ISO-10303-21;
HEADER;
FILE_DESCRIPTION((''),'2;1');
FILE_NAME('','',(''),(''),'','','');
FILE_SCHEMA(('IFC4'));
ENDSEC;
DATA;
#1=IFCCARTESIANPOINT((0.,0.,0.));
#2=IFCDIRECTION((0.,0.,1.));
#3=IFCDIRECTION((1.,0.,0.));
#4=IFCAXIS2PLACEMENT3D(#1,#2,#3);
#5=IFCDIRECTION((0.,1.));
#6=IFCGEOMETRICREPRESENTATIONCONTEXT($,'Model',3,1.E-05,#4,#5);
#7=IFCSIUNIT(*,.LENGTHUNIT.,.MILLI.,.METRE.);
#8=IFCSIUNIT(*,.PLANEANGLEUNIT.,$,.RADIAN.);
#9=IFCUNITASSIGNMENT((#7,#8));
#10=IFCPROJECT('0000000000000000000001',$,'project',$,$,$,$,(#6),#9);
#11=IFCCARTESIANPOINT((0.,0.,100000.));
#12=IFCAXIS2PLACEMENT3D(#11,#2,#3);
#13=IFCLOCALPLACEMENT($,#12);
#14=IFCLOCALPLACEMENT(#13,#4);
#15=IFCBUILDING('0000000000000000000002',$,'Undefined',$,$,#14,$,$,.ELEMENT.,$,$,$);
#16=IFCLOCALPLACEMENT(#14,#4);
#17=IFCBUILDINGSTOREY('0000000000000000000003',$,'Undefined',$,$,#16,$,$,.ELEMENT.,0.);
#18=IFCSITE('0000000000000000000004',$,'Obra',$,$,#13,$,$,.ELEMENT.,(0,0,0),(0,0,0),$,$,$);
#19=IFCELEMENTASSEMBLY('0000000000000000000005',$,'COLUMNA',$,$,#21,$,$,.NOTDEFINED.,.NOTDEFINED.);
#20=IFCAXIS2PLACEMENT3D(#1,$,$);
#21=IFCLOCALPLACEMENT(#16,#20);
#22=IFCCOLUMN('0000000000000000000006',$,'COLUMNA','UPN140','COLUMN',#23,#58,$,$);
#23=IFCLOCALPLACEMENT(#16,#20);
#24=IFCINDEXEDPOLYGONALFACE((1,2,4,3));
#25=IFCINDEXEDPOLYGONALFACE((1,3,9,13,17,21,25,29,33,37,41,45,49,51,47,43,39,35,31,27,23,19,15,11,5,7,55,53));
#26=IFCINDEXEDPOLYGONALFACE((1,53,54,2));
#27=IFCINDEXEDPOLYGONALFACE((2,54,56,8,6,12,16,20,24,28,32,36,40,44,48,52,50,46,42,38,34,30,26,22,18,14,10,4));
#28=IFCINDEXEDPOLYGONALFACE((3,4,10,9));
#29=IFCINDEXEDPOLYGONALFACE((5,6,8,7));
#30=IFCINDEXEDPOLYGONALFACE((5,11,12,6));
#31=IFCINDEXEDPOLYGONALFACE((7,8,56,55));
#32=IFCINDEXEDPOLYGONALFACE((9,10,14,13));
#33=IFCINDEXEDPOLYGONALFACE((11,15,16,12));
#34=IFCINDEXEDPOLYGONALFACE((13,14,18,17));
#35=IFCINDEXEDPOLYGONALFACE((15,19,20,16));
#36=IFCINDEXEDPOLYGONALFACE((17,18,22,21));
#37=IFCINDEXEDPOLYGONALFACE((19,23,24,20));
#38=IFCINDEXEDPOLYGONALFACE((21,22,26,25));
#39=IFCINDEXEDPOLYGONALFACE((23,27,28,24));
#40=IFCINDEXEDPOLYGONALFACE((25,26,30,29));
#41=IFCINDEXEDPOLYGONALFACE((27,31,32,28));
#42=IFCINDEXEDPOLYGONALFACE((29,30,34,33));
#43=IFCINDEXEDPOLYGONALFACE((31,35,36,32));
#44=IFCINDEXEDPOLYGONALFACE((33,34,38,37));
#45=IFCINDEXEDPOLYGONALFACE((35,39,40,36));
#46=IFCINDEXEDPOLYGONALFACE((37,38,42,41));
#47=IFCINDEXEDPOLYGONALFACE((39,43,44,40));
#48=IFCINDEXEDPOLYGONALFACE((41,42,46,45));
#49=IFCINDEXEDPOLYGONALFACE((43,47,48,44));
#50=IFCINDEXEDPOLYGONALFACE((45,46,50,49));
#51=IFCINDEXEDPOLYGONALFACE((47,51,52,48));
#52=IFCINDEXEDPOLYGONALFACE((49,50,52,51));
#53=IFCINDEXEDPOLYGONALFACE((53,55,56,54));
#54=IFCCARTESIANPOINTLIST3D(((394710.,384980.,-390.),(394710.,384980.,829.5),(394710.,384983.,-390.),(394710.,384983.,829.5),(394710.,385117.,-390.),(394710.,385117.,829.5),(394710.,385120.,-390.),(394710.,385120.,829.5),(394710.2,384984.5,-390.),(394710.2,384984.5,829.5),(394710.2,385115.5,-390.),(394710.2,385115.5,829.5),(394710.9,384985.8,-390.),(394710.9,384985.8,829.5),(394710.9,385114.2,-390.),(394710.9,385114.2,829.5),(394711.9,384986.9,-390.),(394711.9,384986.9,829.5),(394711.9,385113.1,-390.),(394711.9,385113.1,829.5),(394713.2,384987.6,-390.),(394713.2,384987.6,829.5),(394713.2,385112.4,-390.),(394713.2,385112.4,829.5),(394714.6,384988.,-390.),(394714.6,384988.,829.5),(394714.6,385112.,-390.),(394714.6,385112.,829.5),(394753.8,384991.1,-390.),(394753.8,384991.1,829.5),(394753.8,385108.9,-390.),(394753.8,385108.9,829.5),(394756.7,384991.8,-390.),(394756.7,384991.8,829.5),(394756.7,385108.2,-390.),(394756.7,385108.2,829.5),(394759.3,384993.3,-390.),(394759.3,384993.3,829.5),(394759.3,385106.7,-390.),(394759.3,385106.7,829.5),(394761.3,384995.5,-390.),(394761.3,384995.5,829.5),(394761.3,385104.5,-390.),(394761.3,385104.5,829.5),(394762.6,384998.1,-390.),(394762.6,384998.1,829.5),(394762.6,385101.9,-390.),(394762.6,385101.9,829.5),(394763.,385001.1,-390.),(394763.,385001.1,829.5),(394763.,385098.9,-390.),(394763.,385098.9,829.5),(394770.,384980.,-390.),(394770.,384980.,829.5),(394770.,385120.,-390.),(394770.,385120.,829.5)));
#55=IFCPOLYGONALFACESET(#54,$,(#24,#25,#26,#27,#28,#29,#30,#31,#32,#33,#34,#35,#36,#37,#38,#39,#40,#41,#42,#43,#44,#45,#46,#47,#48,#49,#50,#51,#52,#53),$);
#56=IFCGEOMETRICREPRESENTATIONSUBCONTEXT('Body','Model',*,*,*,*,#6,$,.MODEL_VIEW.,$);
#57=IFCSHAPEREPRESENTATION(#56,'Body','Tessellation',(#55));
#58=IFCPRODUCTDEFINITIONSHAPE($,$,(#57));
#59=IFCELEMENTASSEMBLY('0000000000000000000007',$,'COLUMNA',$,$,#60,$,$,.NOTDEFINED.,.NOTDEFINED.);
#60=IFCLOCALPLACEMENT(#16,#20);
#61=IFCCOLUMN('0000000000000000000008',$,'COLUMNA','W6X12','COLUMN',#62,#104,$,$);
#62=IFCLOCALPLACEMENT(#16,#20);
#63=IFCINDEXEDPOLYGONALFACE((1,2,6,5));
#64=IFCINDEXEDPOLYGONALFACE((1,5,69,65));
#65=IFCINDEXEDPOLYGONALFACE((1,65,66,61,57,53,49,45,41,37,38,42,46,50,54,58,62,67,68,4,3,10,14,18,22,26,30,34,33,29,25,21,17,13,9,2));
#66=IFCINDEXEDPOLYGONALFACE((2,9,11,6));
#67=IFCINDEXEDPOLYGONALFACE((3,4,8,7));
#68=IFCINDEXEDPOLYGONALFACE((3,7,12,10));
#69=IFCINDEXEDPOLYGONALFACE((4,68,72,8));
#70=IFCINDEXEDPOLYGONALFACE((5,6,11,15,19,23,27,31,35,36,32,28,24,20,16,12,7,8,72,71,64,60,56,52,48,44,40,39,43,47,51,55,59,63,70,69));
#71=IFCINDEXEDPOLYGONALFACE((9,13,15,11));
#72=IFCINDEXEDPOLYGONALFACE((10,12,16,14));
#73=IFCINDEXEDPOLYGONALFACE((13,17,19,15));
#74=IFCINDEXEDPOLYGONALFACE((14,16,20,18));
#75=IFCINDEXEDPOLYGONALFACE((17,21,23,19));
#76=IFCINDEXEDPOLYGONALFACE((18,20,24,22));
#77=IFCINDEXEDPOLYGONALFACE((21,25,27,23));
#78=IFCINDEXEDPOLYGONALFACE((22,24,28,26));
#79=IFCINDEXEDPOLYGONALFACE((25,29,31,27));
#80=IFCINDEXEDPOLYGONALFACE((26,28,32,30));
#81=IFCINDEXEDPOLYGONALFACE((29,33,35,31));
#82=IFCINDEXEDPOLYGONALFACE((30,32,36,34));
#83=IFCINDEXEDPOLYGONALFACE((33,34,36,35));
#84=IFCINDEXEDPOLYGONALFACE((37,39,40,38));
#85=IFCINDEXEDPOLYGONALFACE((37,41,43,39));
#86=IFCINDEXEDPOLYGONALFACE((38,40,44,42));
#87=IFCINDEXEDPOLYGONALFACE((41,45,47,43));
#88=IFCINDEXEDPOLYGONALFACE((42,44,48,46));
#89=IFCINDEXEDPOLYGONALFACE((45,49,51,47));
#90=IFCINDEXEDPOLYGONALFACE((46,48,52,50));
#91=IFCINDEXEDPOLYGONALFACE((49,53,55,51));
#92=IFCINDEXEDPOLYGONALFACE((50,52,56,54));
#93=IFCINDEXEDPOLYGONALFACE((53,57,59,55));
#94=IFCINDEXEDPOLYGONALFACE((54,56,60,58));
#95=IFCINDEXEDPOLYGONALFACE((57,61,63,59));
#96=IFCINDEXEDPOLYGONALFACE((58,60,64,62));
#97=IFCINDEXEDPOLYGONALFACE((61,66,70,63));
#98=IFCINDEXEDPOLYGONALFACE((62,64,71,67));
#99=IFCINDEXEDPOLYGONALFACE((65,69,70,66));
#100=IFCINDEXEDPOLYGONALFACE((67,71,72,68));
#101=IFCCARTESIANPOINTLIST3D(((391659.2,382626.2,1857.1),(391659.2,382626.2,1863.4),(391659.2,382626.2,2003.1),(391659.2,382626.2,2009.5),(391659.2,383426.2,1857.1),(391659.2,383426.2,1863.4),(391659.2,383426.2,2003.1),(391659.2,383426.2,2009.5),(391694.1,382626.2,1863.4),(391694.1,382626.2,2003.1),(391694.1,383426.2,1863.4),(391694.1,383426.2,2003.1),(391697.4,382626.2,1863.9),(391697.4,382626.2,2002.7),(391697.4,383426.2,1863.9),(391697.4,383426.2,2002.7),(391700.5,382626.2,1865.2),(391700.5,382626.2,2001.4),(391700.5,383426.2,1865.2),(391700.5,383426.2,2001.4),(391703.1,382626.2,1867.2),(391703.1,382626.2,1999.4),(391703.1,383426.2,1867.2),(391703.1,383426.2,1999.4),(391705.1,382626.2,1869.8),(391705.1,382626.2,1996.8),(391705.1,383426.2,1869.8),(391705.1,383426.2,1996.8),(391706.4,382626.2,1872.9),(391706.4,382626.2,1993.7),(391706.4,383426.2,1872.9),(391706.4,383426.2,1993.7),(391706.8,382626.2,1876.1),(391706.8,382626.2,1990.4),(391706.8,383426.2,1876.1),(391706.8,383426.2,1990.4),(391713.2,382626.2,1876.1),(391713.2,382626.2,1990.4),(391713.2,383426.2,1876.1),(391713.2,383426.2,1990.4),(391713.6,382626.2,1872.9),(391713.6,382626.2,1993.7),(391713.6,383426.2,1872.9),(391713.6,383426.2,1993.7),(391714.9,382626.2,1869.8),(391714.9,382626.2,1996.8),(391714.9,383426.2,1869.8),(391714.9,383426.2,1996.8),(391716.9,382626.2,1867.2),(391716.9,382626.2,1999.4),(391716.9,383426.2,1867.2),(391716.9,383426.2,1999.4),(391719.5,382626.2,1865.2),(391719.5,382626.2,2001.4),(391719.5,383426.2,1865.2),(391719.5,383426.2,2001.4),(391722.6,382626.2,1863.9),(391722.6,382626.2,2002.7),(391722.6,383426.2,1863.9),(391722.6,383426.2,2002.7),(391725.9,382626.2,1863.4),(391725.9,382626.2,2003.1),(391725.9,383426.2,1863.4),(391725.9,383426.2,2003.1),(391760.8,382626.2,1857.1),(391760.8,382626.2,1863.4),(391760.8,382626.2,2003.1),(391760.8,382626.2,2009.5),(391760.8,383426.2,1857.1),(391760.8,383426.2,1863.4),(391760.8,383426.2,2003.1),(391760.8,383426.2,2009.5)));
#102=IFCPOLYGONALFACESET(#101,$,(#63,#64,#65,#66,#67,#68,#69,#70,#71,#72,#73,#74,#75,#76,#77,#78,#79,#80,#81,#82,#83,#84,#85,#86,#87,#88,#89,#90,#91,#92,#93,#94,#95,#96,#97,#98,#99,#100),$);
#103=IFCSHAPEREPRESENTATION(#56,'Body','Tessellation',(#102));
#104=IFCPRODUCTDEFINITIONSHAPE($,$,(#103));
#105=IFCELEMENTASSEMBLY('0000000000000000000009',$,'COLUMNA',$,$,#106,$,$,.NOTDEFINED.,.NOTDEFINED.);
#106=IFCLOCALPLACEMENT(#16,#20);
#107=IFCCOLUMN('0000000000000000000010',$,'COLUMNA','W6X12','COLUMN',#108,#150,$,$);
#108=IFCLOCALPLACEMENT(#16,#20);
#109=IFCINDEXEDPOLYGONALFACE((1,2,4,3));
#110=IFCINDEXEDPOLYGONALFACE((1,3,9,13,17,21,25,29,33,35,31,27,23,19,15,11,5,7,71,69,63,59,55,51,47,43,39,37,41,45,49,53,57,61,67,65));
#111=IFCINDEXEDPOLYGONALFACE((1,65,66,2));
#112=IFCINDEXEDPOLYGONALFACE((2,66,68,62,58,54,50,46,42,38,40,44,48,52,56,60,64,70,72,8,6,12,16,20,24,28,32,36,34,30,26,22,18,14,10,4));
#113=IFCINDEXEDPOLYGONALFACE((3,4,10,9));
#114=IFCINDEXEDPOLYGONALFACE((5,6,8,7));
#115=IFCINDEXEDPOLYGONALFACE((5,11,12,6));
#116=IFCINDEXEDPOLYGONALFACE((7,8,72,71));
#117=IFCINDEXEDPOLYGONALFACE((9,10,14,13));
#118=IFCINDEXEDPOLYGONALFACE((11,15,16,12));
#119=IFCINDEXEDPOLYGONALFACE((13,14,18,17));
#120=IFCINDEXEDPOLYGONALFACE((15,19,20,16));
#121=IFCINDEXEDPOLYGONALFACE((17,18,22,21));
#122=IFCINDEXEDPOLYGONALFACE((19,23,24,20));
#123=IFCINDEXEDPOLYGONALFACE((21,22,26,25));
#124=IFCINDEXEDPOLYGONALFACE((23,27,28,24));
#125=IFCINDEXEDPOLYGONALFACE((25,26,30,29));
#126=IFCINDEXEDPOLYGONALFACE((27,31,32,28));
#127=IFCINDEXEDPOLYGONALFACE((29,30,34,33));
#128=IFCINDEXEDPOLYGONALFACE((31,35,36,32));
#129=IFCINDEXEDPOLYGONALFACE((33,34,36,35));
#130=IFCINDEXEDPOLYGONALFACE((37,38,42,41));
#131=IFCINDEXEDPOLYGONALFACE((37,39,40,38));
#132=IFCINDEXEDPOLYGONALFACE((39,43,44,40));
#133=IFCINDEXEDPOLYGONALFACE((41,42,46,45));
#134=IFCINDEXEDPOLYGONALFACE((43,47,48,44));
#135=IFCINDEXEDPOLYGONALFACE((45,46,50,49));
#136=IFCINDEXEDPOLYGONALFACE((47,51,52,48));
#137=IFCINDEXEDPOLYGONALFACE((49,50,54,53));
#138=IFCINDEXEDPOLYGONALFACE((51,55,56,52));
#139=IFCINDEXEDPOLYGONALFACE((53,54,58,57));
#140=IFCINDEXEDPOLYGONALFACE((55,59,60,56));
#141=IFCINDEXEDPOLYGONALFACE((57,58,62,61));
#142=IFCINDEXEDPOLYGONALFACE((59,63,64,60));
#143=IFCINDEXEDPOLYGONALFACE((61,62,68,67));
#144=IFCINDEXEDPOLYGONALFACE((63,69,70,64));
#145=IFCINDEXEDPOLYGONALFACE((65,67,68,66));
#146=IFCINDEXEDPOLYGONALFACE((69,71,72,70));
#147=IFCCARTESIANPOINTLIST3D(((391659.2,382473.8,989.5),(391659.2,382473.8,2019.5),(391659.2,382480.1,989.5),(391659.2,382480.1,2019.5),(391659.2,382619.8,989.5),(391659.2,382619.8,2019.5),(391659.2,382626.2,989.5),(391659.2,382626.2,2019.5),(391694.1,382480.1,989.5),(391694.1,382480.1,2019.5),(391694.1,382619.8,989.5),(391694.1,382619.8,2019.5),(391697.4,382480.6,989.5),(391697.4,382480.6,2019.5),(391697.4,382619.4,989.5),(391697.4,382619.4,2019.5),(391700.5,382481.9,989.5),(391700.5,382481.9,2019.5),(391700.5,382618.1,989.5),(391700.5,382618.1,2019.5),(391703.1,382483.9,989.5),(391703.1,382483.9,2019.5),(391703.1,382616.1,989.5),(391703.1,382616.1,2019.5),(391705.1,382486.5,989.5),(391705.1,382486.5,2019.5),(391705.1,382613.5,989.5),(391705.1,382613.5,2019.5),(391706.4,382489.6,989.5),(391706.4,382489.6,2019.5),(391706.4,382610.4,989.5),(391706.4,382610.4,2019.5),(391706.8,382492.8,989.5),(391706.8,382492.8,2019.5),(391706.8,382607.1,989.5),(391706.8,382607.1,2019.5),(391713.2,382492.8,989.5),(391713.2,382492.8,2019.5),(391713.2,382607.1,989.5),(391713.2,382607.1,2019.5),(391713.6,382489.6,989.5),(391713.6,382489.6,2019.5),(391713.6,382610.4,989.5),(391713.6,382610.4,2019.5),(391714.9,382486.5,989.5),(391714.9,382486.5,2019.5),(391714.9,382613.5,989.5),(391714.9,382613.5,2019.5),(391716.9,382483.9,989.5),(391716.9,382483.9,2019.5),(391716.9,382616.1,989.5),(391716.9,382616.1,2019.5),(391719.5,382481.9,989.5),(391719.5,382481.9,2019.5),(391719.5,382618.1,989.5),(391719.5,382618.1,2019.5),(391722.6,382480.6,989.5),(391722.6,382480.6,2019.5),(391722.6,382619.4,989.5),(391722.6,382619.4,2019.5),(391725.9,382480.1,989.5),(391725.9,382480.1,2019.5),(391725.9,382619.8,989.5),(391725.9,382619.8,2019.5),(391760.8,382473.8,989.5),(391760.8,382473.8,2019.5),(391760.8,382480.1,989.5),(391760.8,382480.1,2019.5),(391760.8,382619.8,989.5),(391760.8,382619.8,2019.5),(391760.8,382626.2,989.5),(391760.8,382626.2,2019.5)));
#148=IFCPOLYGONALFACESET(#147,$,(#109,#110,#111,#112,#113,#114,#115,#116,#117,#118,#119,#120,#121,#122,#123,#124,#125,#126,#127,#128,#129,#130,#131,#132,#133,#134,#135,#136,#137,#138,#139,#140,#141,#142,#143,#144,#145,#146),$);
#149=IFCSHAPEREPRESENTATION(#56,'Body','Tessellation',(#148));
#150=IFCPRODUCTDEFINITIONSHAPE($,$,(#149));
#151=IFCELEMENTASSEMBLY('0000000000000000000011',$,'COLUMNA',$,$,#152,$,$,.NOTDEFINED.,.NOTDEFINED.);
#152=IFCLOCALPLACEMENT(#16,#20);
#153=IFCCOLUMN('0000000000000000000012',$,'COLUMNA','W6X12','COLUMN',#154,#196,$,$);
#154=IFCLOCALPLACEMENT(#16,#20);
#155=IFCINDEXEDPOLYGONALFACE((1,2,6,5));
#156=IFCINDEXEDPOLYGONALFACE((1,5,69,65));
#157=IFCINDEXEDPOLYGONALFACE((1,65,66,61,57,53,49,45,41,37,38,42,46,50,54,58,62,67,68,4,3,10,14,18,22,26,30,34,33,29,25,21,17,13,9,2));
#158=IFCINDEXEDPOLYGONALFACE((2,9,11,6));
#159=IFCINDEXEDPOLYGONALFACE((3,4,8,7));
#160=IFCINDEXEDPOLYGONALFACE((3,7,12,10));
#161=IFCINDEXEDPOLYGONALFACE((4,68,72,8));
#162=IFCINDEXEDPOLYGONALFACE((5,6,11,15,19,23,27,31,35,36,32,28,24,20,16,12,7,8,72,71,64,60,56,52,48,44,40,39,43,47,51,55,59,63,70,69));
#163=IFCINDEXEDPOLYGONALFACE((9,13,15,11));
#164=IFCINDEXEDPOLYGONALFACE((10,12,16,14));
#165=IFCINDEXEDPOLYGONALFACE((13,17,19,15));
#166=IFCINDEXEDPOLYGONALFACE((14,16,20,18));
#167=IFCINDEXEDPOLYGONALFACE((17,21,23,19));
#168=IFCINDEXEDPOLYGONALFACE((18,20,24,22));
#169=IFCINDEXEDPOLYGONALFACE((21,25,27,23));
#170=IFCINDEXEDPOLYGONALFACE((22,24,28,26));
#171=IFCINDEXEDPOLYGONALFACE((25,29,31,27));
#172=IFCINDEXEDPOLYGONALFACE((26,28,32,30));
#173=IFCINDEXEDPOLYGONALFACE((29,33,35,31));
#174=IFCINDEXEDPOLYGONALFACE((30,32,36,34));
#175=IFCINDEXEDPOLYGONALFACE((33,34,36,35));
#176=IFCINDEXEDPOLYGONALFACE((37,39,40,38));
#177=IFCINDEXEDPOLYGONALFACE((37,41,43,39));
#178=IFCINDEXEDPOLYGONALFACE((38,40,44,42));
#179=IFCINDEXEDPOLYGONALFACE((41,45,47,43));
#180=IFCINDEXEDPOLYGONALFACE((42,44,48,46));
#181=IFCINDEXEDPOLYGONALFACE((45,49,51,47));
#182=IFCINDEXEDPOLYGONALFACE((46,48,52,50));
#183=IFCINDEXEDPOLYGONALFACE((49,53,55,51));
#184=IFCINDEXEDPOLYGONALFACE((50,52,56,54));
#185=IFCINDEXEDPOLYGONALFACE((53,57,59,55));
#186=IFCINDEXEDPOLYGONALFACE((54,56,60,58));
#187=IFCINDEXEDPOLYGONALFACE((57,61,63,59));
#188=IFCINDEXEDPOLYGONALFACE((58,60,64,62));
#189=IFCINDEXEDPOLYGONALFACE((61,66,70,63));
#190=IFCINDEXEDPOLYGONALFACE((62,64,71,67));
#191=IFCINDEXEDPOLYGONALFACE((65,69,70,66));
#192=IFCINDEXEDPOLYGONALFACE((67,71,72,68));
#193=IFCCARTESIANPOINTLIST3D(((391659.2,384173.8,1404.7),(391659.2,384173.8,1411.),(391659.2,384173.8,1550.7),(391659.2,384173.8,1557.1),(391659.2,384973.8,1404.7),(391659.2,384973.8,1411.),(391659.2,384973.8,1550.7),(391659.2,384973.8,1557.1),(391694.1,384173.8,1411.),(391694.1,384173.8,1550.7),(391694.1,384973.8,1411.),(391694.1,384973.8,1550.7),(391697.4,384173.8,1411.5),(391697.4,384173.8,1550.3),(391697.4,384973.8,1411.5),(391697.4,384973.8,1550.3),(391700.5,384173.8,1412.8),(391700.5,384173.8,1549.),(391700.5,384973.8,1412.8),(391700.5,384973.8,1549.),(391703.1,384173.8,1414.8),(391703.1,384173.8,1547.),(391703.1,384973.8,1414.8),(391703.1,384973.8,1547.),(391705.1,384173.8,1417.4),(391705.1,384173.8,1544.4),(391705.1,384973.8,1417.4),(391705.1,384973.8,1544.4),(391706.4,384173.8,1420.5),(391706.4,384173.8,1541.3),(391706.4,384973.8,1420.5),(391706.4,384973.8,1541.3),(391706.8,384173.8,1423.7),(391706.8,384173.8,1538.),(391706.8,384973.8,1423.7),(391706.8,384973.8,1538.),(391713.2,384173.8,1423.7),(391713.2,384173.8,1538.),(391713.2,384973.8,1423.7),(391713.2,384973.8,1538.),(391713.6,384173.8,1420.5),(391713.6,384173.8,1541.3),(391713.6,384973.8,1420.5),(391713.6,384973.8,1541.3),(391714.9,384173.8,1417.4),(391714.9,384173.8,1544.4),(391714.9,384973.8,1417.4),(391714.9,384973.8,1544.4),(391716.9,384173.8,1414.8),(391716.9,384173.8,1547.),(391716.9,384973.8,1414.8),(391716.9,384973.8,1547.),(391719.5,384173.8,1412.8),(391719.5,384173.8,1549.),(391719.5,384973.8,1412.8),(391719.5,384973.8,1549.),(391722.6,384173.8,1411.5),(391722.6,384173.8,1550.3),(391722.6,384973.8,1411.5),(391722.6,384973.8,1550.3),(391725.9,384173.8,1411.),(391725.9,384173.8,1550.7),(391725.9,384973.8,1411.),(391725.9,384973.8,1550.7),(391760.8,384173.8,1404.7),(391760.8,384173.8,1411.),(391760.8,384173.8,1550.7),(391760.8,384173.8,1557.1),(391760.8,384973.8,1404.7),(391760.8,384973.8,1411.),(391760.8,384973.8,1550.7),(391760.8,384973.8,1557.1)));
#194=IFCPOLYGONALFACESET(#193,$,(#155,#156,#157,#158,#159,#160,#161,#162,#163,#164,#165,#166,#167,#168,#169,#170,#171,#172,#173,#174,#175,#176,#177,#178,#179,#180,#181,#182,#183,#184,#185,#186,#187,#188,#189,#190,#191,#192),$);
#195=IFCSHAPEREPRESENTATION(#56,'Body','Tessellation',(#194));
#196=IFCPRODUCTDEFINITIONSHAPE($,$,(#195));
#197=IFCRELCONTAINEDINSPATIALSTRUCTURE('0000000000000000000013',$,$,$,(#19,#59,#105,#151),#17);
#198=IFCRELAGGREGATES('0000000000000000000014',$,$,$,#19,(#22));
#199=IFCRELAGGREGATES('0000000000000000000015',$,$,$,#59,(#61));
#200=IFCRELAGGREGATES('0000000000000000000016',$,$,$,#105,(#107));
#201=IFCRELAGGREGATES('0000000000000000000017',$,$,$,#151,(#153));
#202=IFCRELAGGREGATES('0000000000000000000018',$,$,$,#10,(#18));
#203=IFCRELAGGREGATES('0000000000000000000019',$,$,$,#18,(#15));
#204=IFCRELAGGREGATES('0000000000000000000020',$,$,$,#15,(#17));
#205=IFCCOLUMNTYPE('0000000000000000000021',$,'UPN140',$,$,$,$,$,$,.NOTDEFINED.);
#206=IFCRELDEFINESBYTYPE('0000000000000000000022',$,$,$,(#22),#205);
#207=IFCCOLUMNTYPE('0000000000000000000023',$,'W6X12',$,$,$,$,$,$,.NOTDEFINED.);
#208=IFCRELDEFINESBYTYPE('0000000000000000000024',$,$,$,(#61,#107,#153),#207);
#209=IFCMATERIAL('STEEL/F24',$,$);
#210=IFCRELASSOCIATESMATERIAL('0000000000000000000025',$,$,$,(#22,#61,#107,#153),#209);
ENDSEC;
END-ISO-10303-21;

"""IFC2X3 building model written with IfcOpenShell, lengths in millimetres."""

from ifc_helpers import new_model, si_unit, direction, frame, origin_with_axes, origin_2d_with_axis, place, context, subcontext, project, spatial, i_section, u_section, extrude, material, type_object, element, aggregate, save


model = new_model("IFC2X3")

# Units and contexts
model_context = context("Model", 3, precision=1e-05, world=origin_with_axes(), true_north=direction((0.0, 1.0)))
body_context = subcontext(model_context, "Body", "Model", "MODEL_VIEW")
ifc_project = project(units=[si_unit("LENGTHUNIT", "METRE", prefix="MILLI"), si_unit("PLANEANGLEUNIT", "RADIAN")], contexts=[model_context])

# Site, building, storey
site_placement = place(None, frame((0.0, 0.0, 100000.0), z_axis=(0.0, 0.0, 1.0), x_axis=(1.0, 0.0, 0.0)))
site = spatial("IfcSite", under=ifc_project, at=site_placement, Name="Obra", CompositionType="ELEMENT", RefLatitude=(0, 0, 0), RefLongitude=(0, 0, 0))
building_placement = place(site_placement, origin_with_axes())
building = spatial("IfcBuilding", under=site, at=building_placement, Name="Undefined", CompositionType="ELEMENT")
storey_placement = place(building_placement, origin_with_axes())
storey = spatial("IfcBuildingStorey", under=building, at=storey_placement, Name="Undefined", CompositionType="ELEMENT", Elevation=0.0)

# Element assemblies, columns
ifc_material_1 = material(Name="STEEL/F24")
column_type_1 = type_object("IfcColumnType", Name="UPN140", PredefinedType="NOTDEFINED")
assembly_1_placement = place(storey_placement, origin_with_axes())
assembly_1 = element("IfcElementAssembly", 1, at=assembly_1_placement, inside=storey, Name="COLUMNA", AssemblyPlace="NOTDEFINED", PredefinedType="NOTDEFINED")
column_1_placement = place(assembly_1_placement, frame((394740.0, 385050.0, -390.0), z_axis=(0.0, 0.0, 1.0), x_axis=(0.0, 1.0, 0.0)))
column_1 = element("IfcColumn", 2, at=column_1_placement, type_object=column_type_1, material=ifc_material_1, Name="COLUMNA", Description="UPN140", ObjectType="COLUMN", context=body_context, shape_type="SweptSolid", body=[
    extrude(u_section(Depth=140.0, FlangeWidth=60.0, WebThickness=7.0, FlangeThickness=10.0, FilletRadius=10.0, EdgeRadius=5.0, FlangeSlope=0.07983, at=origin_2d_with_axis()), frame((0.0, 0.0, 1219.5), z_axis=(0.0, 0.0, -1.0), x_axis=(0.0, 1.0, 0.0)), (0.0, 0.0, 1.0), 1219.5),
])
aggregate(assembly_1, [column_1])
assembly_2_placement = place(storey_placement, origin_with_axes())
assembly_2 = element("IfcElementAssembly", 3, at=assembly_2_placement, inside=storey, Name="COLUMNA", AssemblyPlace="NOTDEFINED", PredefinedType="NOTDEFINED")
column_type_2 = type_object("IfcColumnType", Name="W6X12", PredefinedType="NOTDEFINED")
column_2_placement = place(assembly_2_placement, frame((391710.0, 382626.2, 1933.3), z_axis=(0.0, 1.0, 0.0), x_axis=(0.0, 0.0, -1.0)))
column_2 = element("IfcColumn", 4, at=column_2_placement, type_object=column_type_2, material=ifc_material_1, Name="COLUMNA", Description="W6X12", ObjectType="COLUMN", context=body_context, shape_type="SweptSolid", body=[
    extrude(i_section(OverallWidth=101.6, OverallDepth=152.4, WebThickness=6.3, FlangeThickness=6.3, FilletRadius=12.7, at=origin_2d_with_axis()), frame((0.0, 0.0, 800.0), z_axis=(0.0, 0.0, -1.0), x_axis=(0.0, 1.0, 0.0)), (0.0, 0.0, 1.0), 800.0),
])
aggregate(assembly_2, [column_2])
assembly_3_placement = place(storey_placement, origin_with_axes())
assembly_3 = element("IfcElementAssembly", 5, at=assembly_3_placement, inside=storey, Name="COLUMNA", AssemblyPlace="NOTDEFINED", PredefinedType="NOTDEFINED")
column_3_placement = place(assembly_3_placement, frame((391710.0, 382550.0, 989.5), z_axis=(0.0, 0.0, 1.0), x_axis=(0.0, -1.0, 0.0)))
column_3 = element("IfcColumn", 6, at=column_3_placement, type_object=column_type_2, material=ifc_material_1, Name="COLUMNA", Description="W6X12", ObjectType="COLUMN", context=body_context, shape_type="SweptSolid", body=[
    extrude(i_section(OverallWidth=101.6, OverallDepth=152.4, WebThickness=6.3, FlangeThickness=6.3, FilletRadius=12.7, at=origin_2d_with_axis()), frame((0.0, 0.0, 1030.0), z_axis=(0.0, 0.0, -1.0), x_axis=(0.0, 1.0, 0.0)), (0.0, 0.0, 1.0), 1030.0),
])
aggregate(assembly_3, [column_3])
assembly_4_placement = place(storey_placement, origin_with_axes())
assembly_4 = element("IfcElementAssembly", 7, at=assembly_4_placement, inside=storey, Name="COLUMNA", AssemblyPlace="NOTDEFINED", PredefinedType="NOTDEFINED")
column_4_placement = place(assembly_4_placement, frame((391710.0, 384973.8, 1480.9), z_axis=(0.0, -1.0, 0.0), x_axis=(0.0, 0.0, -1.0)))
column_4 = element("IfcColumn", 8, at=column_4_placement, type_object=column_type_2, material=ifc_material_1, Name="COLUMNA", Description="W6X12", ObjectType="COLUMN", context=body_context, shape_type="SweptSolid", body=[
    extrude(i_section(OverallWidth=101.6, OverallDepth=152.4, WebThickness=6.3, FlangeThickness=6.3, FilletRadius=12.7, at=origin_2d_with_axis()), frame((0.0, 0.0, 800.0), z_axis=(0.0, 0.0, -1.0), x_axis=(0.0, 1.0, 0.0)), (0.0, 0.0, 1.0), 800.0),
])
aggregate(assembly_4, [column_4])

save(model, "model.ifc")
